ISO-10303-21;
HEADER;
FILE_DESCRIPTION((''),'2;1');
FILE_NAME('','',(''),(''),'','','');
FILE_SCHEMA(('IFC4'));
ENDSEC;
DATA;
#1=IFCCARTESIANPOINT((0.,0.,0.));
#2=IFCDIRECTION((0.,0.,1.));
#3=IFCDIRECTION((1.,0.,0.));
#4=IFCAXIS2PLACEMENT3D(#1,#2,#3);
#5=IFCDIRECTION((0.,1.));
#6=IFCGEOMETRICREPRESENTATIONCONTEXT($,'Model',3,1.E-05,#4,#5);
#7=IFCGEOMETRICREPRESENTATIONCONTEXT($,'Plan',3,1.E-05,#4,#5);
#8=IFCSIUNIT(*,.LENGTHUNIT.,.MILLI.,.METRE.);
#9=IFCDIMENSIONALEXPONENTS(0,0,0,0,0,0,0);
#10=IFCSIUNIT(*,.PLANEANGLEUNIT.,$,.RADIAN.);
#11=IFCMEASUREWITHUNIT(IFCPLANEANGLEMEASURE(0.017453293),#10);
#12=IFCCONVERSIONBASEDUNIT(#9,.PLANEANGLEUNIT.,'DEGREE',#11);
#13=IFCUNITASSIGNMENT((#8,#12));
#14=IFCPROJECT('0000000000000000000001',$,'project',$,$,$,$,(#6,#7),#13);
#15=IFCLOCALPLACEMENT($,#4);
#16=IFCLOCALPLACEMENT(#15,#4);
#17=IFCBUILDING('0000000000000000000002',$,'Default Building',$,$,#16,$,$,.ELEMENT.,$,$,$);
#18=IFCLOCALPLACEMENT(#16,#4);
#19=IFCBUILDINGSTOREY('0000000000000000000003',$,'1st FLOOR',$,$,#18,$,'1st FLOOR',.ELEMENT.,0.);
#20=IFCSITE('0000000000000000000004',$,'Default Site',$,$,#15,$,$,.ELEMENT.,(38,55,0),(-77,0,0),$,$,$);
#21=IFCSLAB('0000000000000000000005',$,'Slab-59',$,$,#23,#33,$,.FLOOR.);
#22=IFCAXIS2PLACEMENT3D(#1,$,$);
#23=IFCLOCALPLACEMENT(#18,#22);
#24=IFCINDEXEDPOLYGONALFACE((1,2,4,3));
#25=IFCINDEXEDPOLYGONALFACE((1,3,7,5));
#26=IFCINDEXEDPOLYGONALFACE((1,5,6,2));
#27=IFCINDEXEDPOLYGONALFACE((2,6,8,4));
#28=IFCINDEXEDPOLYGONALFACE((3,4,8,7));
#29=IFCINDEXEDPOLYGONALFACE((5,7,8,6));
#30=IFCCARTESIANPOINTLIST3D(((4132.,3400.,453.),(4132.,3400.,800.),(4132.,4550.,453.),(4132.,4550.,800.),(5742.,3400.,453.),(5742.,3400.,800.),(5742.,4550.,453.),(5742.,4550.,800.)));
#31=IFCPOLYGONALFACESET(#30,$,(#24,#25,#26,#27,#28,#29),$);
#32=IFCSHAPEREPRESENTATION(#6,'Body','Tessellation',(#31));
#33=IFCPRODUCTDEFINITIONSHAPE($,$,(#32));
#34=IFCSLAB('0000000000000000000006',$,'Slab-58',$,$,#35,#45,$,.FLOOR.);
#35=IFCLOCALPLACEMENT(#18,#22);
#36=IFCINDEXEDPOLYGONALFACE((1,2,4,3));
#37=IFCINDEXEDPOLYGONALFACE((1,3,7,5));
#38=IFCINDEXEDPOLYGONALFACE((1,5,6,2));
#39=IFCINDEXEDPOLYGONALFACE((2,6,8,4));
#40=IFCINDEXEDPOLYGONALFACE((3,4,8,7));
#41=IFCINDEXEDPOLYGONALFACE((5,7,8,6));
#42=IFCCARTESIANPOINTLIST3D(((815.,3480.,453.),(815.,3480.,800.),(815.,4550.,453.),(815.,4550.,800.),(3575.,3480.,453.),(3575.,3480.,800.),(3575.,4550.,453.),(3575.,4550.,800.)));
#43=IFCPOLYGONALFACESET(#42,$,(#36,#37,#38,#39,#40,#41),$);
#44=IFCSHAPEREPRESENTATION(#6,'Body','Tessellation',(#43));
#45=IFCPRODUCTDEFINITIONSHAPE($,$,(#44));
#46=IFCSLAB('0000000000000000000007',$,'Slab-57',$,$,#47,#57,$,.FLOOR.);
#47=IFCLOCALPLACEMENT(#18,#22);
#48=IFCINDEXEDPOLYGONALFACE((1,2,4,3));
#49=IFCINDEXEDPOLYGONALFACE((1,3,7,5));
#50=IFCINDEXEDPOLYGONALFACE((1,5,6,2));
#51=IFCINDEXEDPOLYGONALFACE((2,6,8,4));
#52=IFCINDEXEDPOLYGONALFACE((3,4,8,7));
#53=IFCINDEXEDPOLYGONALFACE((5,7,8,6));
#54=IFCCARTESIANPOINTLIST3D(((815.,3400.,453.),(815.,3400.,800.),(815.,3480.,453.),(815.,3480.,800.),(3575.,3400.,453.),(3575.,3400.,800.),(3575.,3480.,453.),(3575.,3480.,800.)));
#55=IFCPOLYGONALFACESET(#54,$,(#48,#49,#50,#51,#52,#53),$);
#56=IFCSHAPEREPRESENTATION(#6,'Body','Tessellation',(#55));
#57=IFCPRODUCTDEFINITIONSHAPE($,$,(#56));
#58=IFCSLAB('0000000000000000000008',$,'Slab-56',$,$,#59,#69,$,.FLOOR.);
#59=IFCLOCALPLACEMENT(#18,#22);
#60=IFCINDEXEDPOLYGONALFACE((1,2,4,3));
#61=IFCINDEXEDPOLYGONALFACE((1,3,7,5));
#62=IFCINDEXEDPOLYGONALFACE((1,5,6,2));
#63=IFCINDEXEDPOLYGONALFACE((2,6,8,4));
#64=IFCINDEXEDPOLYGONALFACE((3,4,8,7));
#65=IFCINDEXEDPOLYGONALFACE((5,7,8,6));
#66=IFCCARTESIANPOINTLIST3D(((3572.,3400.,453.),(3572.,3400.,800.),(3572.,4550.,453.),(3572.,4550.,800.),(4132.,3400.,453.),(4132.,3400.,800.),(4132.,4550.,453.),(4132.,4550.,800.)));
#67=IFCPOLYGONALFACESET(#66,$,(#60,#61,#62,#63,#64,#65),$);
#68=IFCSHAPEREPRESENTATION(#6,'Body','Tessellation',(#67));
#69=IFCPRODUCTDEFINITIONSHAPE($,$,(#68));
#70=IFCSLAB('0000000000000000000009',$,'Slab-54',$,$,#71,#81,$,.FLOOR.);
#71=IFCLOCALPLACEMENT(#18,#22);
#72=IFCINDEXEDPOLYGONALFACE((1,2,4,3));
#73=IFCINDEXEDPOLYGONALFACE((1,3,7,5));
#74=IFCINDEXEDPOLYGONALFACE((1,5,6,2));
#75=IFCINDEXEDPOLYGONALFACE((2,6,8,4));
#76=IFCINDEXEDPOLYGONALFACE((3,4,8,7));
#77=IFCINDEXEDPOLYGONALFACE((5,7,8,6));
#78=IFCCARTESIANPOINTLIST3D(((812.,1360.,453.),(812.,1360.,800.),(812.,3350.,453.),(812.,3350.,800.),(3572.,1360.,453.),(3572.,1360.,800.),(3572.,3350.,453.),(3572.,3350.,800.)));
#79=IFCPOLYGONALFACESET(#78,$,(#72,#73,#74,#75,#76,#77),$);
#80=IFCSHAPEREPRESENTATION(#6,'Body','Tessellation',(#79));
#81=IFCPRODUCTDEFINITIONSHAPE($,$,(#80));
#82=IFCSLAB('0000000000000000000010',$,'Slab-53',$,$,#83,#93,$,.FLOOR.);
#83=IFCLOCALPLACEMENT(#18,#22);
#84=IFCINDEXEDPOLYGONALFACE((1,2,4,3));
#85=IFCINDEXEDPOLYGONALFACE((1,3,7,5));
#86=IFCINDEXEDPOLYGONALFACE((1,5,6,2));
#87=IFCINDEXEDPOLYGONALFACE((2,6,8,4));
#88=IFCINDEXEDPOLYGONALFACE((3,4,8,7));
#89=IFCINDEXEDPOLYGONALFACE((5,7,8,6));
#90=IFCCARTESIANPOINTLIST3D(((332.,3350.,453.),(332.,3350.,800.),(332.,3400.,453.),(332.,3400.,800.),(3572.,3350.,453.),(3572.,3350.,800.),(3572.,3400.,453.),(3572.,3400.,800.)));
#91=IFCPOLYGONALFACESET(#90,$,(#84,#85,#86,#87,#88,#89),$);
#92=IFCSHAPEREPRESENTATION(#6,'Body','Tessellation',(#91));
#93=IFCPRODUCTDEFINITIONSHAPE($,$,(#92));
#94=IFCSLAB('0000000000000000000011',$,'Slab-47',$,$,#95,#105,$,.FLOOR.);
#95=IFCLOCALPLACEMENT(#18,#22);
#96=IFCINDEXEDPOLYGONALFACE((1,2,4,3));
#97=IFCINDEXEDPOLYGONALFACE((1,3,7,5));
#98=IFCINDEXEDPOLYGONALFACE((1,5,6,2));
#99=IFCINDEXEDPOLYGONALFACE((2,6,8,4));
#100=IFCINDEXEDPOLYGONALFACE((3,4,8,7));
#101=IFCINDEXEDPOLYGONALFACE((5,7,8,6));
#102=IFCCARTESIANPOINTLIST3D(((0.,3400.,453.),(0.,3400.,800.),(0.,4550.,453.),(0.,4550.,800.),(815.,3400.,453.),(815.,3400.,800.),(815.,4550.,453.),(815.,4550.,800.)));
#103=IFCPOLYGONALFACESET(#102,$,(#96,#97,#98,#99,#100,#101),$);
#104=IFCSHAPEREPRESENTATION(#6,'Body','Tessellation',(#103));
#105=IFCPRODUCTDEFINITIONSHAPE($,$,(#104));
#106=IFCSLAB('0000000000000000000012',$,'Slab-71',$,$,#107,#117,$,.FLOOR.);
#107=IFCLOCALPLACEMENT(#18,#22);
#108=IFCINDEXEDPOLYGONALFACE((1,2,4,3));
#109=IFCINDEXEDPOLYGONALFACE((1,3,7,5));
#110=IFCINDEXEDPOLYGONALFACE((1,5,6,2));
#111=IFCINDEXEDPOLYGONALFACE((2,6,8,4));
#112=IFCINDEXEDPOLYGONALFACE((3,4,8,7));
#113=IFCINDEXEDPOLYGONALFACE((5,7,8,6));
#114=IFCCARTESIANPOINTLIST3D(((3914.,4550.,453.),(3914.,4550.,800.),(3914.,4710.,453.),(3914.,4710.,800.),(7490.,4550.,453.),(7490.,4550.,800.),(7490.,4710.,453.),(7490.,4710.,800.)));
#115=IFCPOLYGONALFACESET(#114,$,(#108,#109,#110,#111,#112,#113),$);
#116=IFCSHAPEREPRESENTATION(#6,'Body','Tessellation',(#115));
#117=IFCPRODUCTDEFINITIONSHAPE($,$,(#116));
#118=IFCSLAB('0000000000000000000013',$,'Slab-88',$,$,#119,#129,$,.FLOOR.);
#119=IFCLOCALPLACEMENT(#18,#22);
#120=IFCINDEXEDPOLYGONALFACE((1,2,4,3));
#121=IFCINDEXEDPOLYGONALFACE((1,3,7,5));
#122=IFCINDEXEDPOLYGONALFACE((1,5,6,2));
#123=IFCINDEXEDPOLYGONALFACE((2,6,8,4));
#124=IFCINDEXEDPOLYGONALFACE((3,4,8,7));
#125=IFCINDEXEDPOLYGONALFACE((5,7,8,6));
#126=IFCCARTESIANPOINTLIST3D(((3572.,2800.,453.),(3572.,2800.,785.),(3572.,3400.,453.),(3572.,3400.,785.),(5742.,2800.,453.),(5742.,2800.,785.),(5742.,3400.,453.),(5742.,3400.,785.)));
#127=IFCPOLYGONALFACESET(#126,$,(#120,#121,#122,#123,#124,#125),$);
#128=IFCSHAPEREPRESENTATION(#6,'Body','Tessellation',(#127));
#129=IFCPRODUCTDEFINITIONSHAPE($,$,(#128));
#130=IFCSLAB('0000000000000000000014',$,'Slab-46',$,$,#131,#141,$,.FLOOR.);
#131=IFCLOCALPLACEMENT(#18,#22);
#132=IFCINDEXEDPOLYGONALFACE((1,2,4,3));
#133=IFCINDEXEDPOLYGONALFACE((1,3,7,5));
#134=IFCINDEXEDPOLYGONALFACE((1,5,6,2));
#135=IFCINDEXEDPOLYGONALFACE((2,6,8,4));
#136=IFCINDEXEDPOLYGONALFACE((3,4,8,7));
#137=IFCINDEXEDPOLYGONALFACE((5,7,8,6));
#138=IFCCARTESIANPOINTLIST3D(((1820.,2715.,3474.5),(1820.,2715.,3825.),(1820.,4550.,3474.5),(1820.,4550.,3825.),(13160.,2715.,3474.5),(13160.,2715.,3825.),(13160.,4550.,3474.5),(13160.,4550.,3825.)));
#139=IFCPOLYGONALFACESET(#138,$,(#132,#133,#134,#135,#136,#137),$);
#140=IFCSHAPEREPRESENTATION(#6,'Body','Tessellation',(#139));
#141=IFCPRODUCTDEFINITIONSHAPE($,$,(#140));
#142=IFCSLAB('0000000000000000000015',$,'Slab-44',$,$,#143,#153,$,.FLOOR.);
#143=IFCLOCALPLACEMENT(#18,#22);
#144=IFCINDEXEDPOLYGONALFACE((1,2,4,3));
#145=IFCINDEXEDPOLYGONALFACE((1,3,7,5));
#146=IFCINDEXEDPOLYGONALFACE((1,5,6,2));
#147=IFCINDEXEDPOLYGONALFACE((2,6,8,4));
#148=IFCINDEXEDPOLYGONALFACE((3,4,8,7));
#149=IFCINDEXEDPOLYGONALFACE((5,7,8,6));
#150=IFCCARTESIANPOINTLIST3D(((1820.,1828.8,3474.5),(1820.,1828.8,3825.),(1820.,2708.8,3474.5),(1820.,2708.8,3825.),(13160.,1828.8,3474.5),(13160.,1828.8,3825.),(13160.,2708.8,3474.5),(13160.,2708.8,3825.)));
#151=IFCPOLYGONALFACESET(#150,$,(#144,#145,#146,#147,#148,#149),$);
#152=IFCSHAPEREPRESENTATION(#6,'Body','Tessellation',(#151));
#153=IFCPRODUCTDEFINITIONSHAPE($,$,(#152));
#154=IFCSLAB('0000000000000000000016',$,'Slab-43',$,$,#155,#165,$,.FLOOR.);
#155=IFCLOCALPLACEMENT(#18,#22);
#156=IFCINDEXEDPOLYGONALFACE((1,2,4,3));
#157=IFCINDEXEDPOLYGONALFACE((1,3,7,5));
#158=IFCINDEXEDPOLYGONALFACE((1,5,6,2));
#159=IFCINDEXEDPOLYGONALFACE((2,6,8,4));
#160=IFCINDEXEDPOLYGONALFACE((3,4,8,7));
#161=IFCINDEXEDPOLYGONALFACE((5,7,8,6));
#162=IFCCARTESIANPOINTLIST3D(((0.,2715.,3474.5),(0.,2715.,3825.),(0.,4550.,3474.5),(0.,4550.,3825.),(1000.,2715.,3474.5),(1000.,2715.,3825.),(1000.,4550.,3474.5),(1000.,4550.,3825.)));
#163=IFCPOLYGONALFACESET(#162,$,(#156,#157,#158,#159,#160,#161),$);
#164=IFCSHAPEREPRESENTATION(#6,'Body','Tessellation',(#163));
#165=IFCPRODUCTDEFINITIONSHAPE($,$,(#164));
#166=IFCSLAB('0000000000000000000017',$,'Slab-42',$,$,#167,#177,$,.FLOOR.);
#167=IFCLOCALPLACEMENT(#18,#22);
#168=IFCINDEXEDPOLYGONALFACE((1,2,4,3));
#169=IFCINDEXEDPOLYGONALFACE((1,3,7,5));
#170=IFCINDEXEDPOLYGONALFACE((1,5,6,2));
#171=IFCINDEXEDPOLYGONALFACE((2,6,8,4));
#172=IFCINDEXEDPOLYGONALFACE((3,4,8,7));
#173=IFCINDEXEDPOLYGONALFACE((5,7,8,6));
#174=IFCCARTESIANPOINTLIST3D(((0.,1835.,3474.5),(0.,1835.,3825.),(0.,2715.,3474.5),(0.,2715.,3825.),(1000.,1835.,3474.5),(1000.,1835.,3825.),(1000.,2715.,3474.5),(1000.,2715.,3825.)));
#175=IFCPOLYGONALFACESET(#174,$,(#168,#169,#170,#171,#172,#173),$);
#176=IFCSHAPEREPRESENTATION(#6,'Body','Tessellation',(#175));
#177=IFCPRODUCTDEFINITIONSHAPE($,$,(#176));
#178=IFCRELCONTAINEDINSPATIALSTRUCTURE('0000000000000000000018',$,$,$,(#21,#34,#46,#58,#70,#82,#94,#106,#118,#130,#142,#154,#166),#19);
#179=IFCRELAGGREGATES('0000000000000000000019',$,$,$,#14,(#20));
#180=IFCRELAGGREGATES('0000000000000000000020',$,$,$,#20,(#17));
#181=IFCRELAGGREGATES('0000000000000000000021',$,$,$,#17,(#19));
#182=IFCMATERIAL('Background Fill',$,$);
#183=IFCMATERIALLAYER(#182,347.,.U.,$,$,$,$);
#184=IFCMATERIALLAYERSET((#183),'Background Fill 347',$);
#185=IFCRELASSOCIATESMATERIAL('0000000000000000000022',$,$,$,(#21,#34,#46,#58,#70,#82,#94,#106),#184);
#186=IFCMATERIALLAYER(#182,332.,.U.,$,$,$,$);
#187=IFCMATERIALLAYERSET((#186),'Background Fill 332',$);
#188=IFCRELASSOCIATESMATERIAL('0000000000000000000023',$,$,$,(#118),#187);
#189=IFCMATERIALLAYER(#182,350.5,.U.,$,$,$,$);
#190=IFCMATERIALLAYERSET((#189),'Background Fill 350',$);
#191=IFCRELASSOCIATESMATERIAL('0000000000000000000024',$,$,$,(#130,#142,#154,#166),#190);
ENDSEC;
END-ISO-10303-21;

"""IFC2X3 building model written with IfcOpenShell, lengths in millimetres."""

from ifc_helpers import new_model, entity, si_unit, converted_unit, direction, frame, origin_with_axes, place, context, project, spatial, polyline, outline, extrude, material, layer, layer_set, layer_usage, element, save


model = new_model("IFC2X3")

# Units and contexts
model_context = context("Model", 3, precision=1e-05, world=origin_with_axes(), true_north=direction((0.0, 1.0)))
plan_context = context("Plan", 3, precision=1e-05, world=origin_with_axes(), true_north=direction((0.0, 1.0)))
ifc_project = project(units=[si_unit("LENGTHUNIT", "METRE", prefix="MILLI"), converted_unit("PLANEANGLEUNIT", "DEGREE", entity("IfcPlaneAngleMeasure", 0.017453293), si_unit("PLANEANGLEUNIT", "RADIAN"), dimensions=[0, 0, 0, 0, 0, 0, 0])], contexts=[model_context, plan_context])

# Site, building, storey
site_placement = place(None, origin_with_axes())
site = spatial("IfcSite", under=ifc_project, at=site_placement, Name="Default Site", CompositionType="ELEMENT", RefLatitude=(38, 55, 0), RefLongitude=(-77, 0, 0))
building_placement = place(site_placement, origin_with_axes())
building = spatial("IfcBuilding", under=site, at=building_placement, Name="Default Building", CompositionType="ELEMENT")
storey_placement = place(building_placement, origin_with_axes())
storey = spatial("IfcBuildingStorey", under=building, at=storey_placement, Name="1st FLOOR", LongName="1st FLOOR", CompositionType="ELEMENT", Elevation=0.0)

# Slabs
ifc_material = material(Name="Background Fill")
ifc_layer_1 = layer(ifc_material, 347.0, ventilated="UNKNOWN")
ifc_layer_set_1 = layer_set([ifc_layer_1], Name="Background Fill 347")
ifc_layer_usage_1 = layer_usage(ifc_layer_set_1, "AXIS3", "NEGATIVE", 347.0)
slab_1_placement = place(storey_placement, frame((4132.0, 3400.0, 453.0), z_axis=(0.0, 0.0, 1.0), x_axis=(1.0, 0.0, 0.0)))
element("IfcSlab", 1, at=slab_1_placement, inside=storey, material=ifc_layer_usage_1, Name="Slab-59", PredefinedType="FLOOR", context=model_context, shape_type="SweptSolid", body=[
    extrude(outline(polyline([(0.0, 0.0), (1610.0, 0.0), (1610.0, 1150.0), (0.0, 1150.0), (0.0, 0.0)])), origin_with_axes(), (0.0, 0.0, 1.0), 347.0),
])
ifc_layer_usage_2 = layer_usage(ifc_layer_set_1, "AXIS3", "NEGATIVE", 347.0)
slab_2_placement = place(storey_placement, frame((815.0, 3480.0, 453.0), z_axis=(0.0, 0.0, 1.0), x_axis=(1.0, 0.0, 0.0)))
element("IfcSlab", 2, at=slab_2_placement, inside=storey, material=ifc_layer_usage_2, Name="Slab-58", PredefinedType="FLOOR", context=model_context, shape_type="SweptSolid", body=[
    extrude(outline(polyline([(0.0, 0.0), (2760.0, 0.0), (2760.0, 1070.0), (0.0, 1070.0), (0.0, 0.0)])), origin_with_axes(), (0.0, 0.0, 1.0), 347.0),
])
ifc_layer_usage_3 = layer_usage(ifc_layer_set_1, "AXIS3", "NEGATIVE", 347.0)
slab_3_placement = place(storey_placement, frame((815.0, 3400.0, 453.0), z_axis=(0.0, 0.0, 1.0), x_axis=(1.0, 0.0, 0.0)))
element("IfcSlab", 3, at=slab_3_placement, inside=storey, material=ifc_layer_usage_3, Name="Slab-57", PredefinedType="FLOOR", context=model_context, shape_type="SweptSolid", body=[
    extrude(outline(polyline([(0.0, 0.0), (2760.0, 0.0), (2760.0, 80.0), (0.0, 80.0), (0.0, 0.0)])), origin_with_axes(), (0.0, 0.0, 1.0), 347.0),
])
ifc_layer_usage_4 = layer_usage(ifc_layer_set_1, "AXIS3", "NEGATIVE", 347.0)
slab_4_placement = place(storey_placement, frame((3572.0, 3400.0, 453.0), z_axis=(0.0, 0.0, 1.0), x_axis=(1.0, 0.0, 0.0)))
element("IfcSlab", 4, at=slab_4_placement, inside=storey, material=ifc_layer_usage_4, Name="Slab-56", PredefinedType="FLOOR", context=model_context, shape_type="SweptSolid", body=[
    extrude(outline(polyline([(0.0, 0.0), (560.0, 0.0), (560.0, 1150.0), (0.0, 1150.0), (0.0, 0.0)])), origin_with_axes(), (0.0, 0.0, 1.0), 347.0),
])
ifc_layer_usage_5 = layer_usage(ifc_layer_set_1, "AXIS3", "NEGATIVE", 347.0)
slab_5_placement = place(storey_placement, frame((812.0, 1360.0, 453.0), z_axis=(0.0, 0.0, 1.0), x_axis=(1.0, 0.0, 0.0)))
element("IfcSlab", 5, at=slab_5_placement, inside=storey, material=ifc_layer_usage_5, Name="Slab-54", PredefinedType="FLOOR", context=model_context, shape_type="SweptSolid", body=[
    extrude(outline(polyline([(0.0, 0.0), (2760.0, 0.0), (2760.0, 1990.0), (0.0, 1990.0), (0.0, 0.0)])), origin_with_axes(), (0.0, 0.0, 1.0), 347.0),
])
ifc_layer_usage_6 = layer_usage(ifc_layer_set_1, "AXIS3", "NEGATIVE", 347.0)
slab_6_placement = place(storey_placement, frame((332.0, 3350.0, 453.0), z_axis=(0.0, 0.0, 1.0), x_axis=(1.0, 0.0, 0.0)))
element("IfcSlab", 6, at=slab_6_placement, inside=storey, material=ifc_layer_usage_6, Name="Slab-53", PredefinedType="FLOOR", context=model_context, shape_type="SweptSolid", body=[
    extrude(outline(polyline([(0.0, 0.0), (3240.0, 0.0), (3240.0, 50.0), (0.0, 50.0), (0.0, 0.0)])), origin_with_axes(), (0.0, 0.0, 1.0), 347.0),
])
ifc_layer_usage_7 = layer_usage(ifc_layer_set_1, "AXIS3", "NEGATIVE", 347.0)
slab_7_placement = place(storey_placement, frame((0.0, 3400.0, 453.0), z_axis=(0.0, 0.0, 1.0), x_axis=(1.0, 0.0, 0.0)))
element("IfcSlab", 7, at=slab_7_placement, inside=storey, material=ifc_layer_usage_7, Name="Slab-47", PredefinedType="FLOOR", context=model_context, shape_type="SweptSolid", body=[
    extrude(outline(polyline([(0.0, 0.0), (815.0, 0.0), (815.0, 1150.0), (0.0, 1150.0), (0.0, 0.0)])), origin_with_axes(), (0.0, 0.0, 1.0), 347.0),
])
ifc_layer_usage_8 = layer_usage(ifc_layer_set_1, "AXIS3", "NEGATIVE", 347.0)
slab_8_placement = place(storey_placement, frame((3914.0, 4550.0, 453.0), z_axis=(0.0, 0.0, 1.0), x_axis=(1.0, 0.0, 0.0)))
element("IfcSlab", 8, at=slab_8_placement, inside=storey, material=ifc_layer_usage_8, Name="Slab-71", PredefinedType="FLOOR", context=model_context, shape_type="SweptSolid", body=[
    extrude(outline(polyline([(0.0, 0.0), (3576.0, 0.0), (3576.0, 160.0), (0.0, 160.0), (0.0, 0.0)])), origin_with_axes(), (0.0, 0.0, 1.0), 347.0),
])
ifc_layer_2 = layer(ifc_material, 332.0, ventilated="UNKNOWN")
ifc_layer_set_2 = layer_set([ifc_layer_2], Name="Background Fill 332")
ifc_layer_usage_9 = layer_usage(ifc_layer_set_2, "AXIS3", "NEGATIVE", 332.0)
slab_9_placement = place(storey_placement, frame((3572.0, 2800.0, 453.0), z_axis=(0.0, 0.0, 1.0), x_axis=(1.0, 0.0, 0.0)))
element("IfcSlab", 9, at=slab_9_placement, inside=storey, material=ifc_layer_usage_9, Name="Slab-88", PredefinedType="FLOOR", context=model_context, shape_type="SweptSolid", body=[
    extrude(outline(polyline([(0.0, 0.0), (2170.0, 0.0), (2170.0, 600.0), (0.0, 600.0), (0.0, 0.0)])), origin_with_axes(), (0.0, 0.0, 1.0), 332.0),
])
ifc_layer_3 = layer(ifc_material, 350.5, ventilated="UNKNOWN")
ifc_layer_set_3 = layer_set([ifc_layer_3], Name="Background Fill 350")
ifc_layer_usage_10 = layer_usage(ifc_layer_set_3, "AXIS3", "NEGATIVE", 350.5)
slab_10_placement = place(storey_placement, frame((1820.0, 4550.0, 3474.5), z_axis=(0.0, 0.0, 1.0), x_axis=(1.0, 0.0, 0.0)))
element("IfcSlab", 10, at=slab_10_placement, inside=storey, material=ifc_layer_usage_10, Name="Slab-46", PredefinedType="FLOOR", context=model_context, shape_type="SweptSolid", body=[
    extrude(outline(polyline([(0.0, 0.0), (11340.0, 0.0), (11340.0, -1835.0), (0.0, -1835.0), (0.0, 0.0)])), origin_with_axes(), (0.0, 0.0, 1.0), 350.5),
])
ifc_layer_usage_11 = layer_usage(ifc_layer_set_3, "AXIS3", "NEGATIVE", 350.5)
slab_11_placement = place(storey_placement, frame((1820.0, 1828.8, 3474.5), z_axis=(0.0, 0.0, 1.0), x_axis=(1.0, 0.0, 0.0)))
element("IfcSlab", 11, at=slab_11_placement, inside=storey, material=ifc_layer_usage_11, Name="Slab-44", PredefinedType="FLOOR", context=model_context, shape_type="SweptSolid", body=[
    extrude(outline(polyline([(0.0, 0.0), (11340.0, 0.0), (11340.0, 880.0), (0.0, 880.0), (0.0, 0.0)])), origin_with_axes(), (0.0, 0.0, 1.0), 350.5),
])
ifc_layer_usage_12 = layer_usage(ifc_layer_set_3, "AXIS3", "NEGATIVE", 350.5)
slab_12_placement = place(storey_placement, frame((0.0, 4550.0, 3474.5), z_axis=(0.0, 0.0, 1.0), x_axis=(1.0, 0.0, 0.0)))
element("IfcSlab", 12, at=slab_12_placement, inside=storey, material=ifc_layer_usage_12, Name="Slab-43", PredefinedType="FLOOR", context=model_context, shape_type="SweptSolid", body=[
    extrude(outline(polyline([(0.0, 0.0), (1000.0, 0.0), (1000.0, -1835.0), (0.0, -1835.0), (0.0, 0.0)])), origin_with_axes(), (0.0, 0.0, 1.0), 350.5),
])
ifc_layer_usage_13 = layer_usage(ifc_layer_set_3, "AXIS3", "NEGATIVE", 350.5)
slab_13_placement = place(storey_placement, frame((0.0, 1835.0, 3474.5), z_axis=(0.0, 0.0, 1.0), x_axis=(1.0, 0.0, 0.0)))
element("IfcSlab", 13, at=slab_13_placement, inside=storey, material=ifc_layer_usage_13, Name="Slab-42", PredefinedType="FLOOR", context=model_context, shape_type="SweptSolid", body=[
    extrude(outline(polyline([(0.0, 0.0), (1000.0, 0.0), (1000.0, 880.0), (0.0, 880.0), (0.0, 0.0)])), origin_with_axes(), (0.0, 0.0, 1.0), 350.5),
])

save(model, "model.ifc")
